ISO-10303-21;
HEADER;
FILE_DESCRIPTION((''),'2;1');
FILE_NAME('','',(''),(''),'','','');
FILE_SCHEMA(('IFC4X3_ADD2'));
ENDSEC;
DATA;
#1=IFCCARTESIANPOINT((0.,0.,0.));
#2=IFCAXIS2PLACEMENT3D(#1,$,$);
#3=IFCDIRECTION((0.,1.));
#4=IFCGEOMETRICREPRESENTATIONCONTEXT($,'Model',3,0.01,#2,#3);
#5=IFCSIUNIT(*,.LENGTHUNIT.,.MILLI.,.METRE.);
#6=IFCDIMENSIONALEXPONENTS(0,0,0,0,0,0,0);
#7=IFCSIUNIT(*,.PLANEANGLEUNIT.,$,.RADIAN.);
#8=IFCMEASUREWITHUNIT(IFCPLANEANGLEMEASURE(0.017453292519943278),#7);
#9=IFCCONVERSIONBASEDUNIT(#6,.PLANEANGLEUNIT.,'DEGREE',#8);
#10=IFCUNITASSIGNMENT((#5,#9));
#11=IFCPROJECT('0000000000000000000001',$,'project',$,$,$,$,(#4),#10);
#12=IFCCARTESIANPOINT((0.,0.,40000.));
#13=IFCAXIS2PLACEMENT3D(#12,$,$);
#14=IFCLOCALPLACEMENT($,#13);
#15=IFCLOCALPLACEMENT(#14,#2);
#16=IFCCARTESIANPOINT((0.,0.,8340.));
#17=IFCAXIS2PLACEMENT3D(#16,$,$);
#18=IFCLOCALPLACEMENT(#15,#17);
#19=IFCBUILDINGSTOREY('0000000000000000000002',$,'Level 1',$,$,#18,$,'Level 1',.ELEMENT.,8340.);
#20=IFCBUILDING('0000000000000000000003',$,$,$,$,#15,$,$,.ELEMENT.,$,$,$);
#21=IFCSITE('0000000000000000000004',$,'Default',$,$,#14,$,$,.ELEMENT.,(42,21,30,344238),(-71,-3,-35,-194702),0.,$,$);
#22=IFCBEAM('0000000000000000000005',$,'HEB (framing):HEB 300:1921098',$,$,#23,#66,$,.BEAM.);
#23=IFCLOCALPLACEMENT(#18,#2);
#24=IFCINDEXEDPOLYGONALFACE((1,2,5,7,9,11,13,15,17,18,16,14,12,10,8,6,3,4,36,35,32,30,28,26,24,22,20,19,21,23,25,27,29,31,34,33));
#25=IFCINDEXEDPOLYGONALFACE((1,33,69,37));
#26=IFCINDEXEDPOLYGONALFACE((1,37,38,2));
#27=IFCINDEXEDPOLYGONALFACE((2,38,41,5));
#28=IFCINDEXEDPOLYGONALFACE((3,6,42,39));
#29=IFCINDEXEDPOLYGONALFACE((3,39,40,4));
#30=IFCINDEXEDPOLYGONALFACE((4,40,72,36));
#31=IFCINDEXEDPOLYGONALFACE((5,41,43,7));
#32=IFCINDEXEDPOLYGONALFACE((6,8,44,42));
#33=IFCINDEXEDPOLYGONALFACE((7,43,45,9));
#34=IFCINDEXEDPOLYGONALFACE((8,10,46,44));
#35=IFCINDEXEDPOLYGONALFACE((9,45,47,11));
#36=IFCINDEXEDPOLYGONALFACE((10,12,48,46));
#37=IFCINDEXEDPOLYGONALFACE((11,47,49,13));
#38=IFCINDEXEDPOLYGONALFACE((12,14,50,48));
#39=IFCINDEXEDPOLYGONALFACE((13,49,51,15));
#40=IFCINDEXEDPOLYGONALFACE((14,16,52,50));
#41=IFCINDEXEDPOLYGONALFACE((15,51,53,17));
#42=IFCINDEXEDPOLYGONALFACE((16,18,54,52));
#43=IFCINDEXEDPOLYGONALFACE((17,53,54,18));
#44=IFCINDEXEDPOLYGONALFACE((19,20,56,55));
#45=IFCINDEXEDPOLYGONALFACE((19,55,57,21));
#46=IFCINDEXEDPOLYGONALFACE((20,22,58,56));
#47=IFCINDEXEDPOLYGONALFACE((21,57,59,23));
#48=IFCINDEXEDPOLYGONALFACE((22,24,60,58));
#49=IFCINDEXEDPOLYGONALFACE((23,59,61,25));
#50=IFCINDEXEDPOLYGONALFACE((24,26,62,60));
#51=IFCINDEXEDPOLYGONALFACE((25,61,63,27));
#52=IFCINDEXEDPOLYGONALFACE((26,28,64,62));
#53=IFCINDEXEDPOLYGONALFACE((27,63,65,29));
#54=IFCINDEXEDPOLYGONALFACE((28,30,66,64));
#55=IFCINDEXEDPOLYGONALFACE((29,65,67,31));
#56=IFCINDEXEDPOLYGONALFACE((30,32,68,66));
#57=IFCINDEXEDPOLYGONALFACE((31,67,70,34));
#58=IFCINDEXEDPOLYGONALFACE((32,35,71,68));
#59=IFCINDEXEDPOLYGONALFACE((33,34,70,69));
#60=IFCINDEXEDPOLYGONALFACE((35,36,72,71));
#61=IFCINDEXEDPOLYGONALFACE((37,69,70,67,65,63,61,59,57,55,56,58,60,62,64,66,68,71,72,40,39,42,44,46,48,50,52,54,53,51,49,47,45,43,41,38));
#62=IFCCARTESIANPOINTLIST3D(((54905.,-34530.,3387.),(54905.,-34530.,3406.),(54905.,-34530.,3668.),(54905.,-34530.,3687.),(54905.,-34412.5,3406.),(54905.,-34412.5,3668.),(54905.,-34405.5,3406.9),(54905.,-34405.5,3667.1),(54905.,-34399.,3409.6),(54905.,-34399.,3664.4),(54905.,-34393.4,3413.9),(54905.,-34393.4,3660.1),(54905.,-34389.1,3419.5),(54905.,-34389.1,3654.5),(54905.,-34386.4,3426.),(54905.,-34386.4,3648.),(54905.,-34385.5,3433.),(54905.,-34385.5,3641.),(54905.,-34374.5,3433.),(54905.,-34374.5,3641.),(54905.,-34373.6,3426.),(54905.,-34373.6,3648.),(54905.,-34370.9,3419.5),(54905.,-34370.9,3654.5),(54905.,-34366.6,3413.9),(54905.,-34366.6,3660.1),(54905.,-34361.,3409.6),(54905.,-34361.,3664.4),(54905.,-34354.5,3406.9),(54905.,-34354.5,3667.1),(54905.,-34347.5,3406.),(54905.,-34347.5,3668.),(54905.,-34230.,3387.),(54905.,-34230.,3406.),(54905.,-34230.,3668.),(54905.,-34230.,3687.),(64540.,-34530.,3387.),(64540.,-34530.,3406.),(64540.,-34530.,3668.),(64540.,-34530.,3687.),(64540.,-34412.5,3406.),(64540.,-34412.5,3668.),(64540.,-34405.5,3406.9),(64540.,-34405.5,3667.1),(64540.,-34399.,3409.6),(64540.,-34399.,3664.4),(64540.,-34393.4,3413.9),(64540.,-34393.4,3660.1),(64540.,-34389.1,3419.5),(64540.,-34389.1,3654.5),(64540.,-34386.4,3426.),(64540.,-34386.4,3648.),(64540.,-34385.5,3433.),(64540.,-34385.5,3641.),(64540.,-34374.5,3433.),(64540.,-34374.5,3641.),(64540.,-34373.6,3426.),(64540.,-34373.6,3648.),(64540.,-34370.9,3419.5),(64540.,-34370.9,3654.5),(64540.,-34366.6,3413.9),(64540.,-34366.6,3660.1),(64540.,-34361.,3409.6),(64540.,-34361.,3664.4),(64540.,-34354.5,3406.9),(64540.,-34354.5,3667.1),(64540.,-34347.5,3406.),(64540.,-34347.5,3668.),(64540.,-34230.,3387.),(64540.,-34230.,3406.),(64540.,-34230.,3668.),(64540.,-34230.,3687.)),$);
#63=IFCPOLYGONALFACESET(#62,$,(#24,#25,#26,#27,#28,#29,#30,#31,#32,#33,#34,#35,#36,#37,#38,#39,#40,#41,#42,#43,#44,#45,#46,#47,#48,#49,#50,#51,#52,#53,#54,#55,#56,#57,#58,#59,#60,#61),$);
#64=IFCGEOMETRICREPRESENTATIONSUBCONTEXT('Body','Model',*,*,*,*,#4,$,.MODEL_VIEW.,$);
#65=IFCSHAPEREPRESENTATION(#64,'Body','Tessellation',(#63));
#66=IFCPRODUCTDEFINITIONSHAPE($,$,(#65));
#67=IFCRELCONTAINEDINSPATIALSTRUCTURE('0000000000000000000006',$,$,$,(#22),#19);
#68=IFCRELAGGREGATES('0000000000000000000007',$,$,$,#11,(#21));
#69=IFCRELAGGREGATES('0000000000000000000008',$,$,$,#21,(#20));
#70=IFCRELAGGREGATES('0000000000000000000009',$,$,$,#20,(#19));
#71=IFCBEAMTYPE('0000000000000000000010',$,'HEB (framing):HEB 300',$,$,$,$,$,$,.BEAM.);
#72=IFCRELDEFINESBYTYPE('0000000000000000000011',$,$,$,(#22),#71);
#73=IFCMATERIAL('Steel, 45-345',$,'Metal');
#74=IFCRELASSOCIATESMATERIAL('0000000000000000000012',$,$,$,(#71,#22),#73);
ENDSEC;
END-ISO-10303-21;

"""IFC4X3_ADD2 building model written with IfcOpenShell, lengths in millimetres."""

from ifc_helpers import new_model, entity, si_unit, converted_unit, direction, frame, frame_2d, origin, place, context, subcontext, project, spatial, polyline, circle_curve, parameter, trimmed, segment, composite_curve, outline, extrude, source, transform, mapped, material, material_profile, profile_set, profile_usage, type_object, type_shapes, element, save


model = new_model("IFC4X3_ADD2")

# Units and contexts
model_context = context("Model", 3, precision=0.01, world=origin(), true_north=direction((0.0, 1.0)))
body_context = subcontext(model_context, "Body", "Model", "MODEL_VIEW")
ifc_project = project(units=[si_unit("LENGTHUNIT", "METRE", prefix="MILLI"), converted_unit("PLANEANGLEUNIT", "DEGREE", entity("IfcPlaneAngleMeasure", 0.017453292519943278), si_unit("PLANEANGLEUNIT", "RADIAN"), dimensions=[0, 0, 0, 0, 0, 0, 0])], contexts=[model_context])

# Site, building, storey
site_placement = place(None, frame((0.0, 0.0, 40000.0)))
site = spatial("IfcSite", under=ifc_project, at=site_placement, Name="Default", CompositionType="ELEMENT", RefLatitude=(42, 21, 30, 344238), RefLongitude=(-71, -3, -35, -194702), RefElevation=0.0)
building_placement = place(site_placement, origin())
building = spatial("IfcBuilding", under=site, at=building_placement, CompositionType="ELEMENT")
storey_placement = place(building_placement, frame((0.0, 0.0, 8340.0)))
storey = spatial("IfcBuildingStorey", under=building, at=storey_placement, Name="Level 1", LongName="Level 1", CompositionType="ELEMENT", Elevation=8340.0)

# Shared definitions
ifc_material_1 = material(Name="Steel, 45-345", Category="Metal")

# Beam
ifc_material_profile_1 = material_profile(ifc_material_1, outline(composite_curve([segment(polyline([(-150.0, -131.0), (-150.0, -150.0)]), True, "CONTINUOUS"), segment(polyline([(-150.0, -150.0), (150.0, -150.0)]), True, "CONTINUOUS"), segment(polyline([(150.0, -150.0), (150.0, -131.0)]), True, "CONTINUOUS"), segment(polyline([(150.0, -131.0), (32.5, -131.0)]), True, "CONTINUOUS"), segment(trimmed(circle_curve(frame_2d((32.5, -104.0), x_axis=(1.0, 0.0)), 27.0), [parameter(180.0)], [parameter(270.0)], True, "PARAMETER"), False, "CONTINUOUS"), segment(polyline([(5.5, -104.0), (5.5, 104.0)]), True, "CONTINUOUS"), segment(trimmed(circle_curve(frame_2d((32.5, 104.0), x_axis=(1.0, 0.0)), 27.0), [parameter(90.0)], [parameter(180.0)], True, "PARAMETER"), False, "CONTINUOUS"), segment(polyline([(32.5, 131.0), (150.0, 131.0)]), True, "CONTINUOUS"), segment(polyline([(150.0, 131.0), (150.0, 150.0)]), True, "CONTINUOUS"), segment(polyline([(150.0, 150.0), (-150.0, 150.0)]), True, "CONTINUOUS"), segment(polyline([(-150.0, 150.0), (-150.0, 131.0)]), True, "CONTINUOUS"), segment(polyline([(-150.0, 131.0), (-32.5, 131.0)]), True, "CONTINUOUS"), segment(trimmed(circle_curve(frame_2d((-32.5, 104.0), x_axis=(1.0, 0.0)), 27.0), [parameter(360.0)], [parameter(90.0)], True, "PARAMETER"), False, "CONTINUOUS"), segment(polyline([(-5.5, 104.0), (-5.5, -104.0)]), True, "CONTINUOUS"), segment(trimmed(circle_curve(frame_2d((-32.5, -104.0), x_axis=(1.0, 0.0)), 27.0), [parameter(270.0)], [parameter(0.0)], True, "PARAMETER"), False, "CONTINUOUS"), segment(polyline([(-32.5, -131.0), (-150.0, -131.0)]), True, "CONTINUOUS")], self_intersect=False)), Name="HEB 300")
ifc_profile_set_1 = profile_set([ifc_material_profile_1], Name="HEB 300")
ifc_profile_usage_1 = profile_usage(ifc_profile_set_1, cardinal=8)
beam_type_1 = type_object("IfcBeamType", Name="HEB (framing):HEB 300", PredefinedType="BEAM", material=ifc_profile_set_1)
shared_shape_1 = source(origin(), body_context, "Body", "SweptSolid", [
    extrude(outline(composite_curve([segment(polyline([(-150.0, -131.0), (-150.0, -150.0)]), True, "CONTINUOUS"), segment(polyline([(-150.0, -150.0), (150.0, -150.0)]), True, "CONTINUOUS"), segment(polyline([(150.0, -150.0), (150.0, -131.0)]), True, "CONTINUOUS"), segment(polyline([(150.0, -131.0), (32.5, -131.0)]), True, "CONTINUOUS"), segment(trimmed(circle_curve(frame_2d((32.5, -104.0), x_axis=(1.0, 0.0)), 27.0), [parameter(180.0)], [parameter(270.0)], True, "PARAMETER"), False, "CONTINUOUS"), segment(polyline([(5.5, -104.0), (5.5, 104.0)]), True, "CONTINUOUS"), segment(trimmed(circle_curve(frame_2d((32.5, 104.0), x_axis=(1.0, 0.0)), 27.0), [parameter(90.0)], [parameter(180.0)], True, "PARAMETER"), False, "CONTINUOUS"), segment(polyline([(32.5, 131.0), (150.0, 131.0)]), True, "CONTINUOUS"), segment(polyline([(150.0, 131.0), (150.0, 150.0)]), True, "CONTINUOUS"), segment(polyline([(150.0, 150.0), (-150.0, 150.0)]), True, "CONTINUOUS"), segment(polyline([(-150.0, 150.0), (-150.0, 131.0)]), True, "CONTINUOUS"), segment(polyline([(-150.0, 131.0), (-32.5, 131.0)]), True, "CONTINUOUS"), segment(trimmed(circle_curve(frame_2d((-32.5, 104.0), x_axis=(1.0, 0.0)), 27.0), [parameter(360.0)], [parameter(90.0)], True, "PARAMETER"), False, "CONTINUOUS"), segment(polyline([(-5.5, 104.0), (-5.5, -104.0)]), True, "CONTINUOUS"), segment(trimmed(circle_curve(frame_2d((-32.5, -104.0), x_axis=(1.0, 0.0)), 27.0), [parameter(270.0)], [parameter(0.0)], True, "PARAMETER"), False, "CONTINUOUS"), segment(polyline([(-32.5, -131.0), (-150.0, -131.0)]), True, "CONTINUOUS")], self_intersect=False)), frame((-4700.0, 0.0, 0.0), z_axis=(-1.0, 0.0, 0.0), x_axis=(0.0, -1.0, 0.0)), (0.0, 0.0, -1.0), 9635.0),
])
type_shapes(beam_type_1, [shared_shape_1])
beam_1_placement = place(storey_placement, frame((59605.0, -34380.0, 3537.0)))
element("IfcBeam", 1, at=beam_1_placement, inside=storey, type_object=beam_type_1, material=ifc_profile_usage_1, Name="HEB (framing):HEB 300:1921098", PredefinedType="BEAM", context=body_context, shape_type="MappedRepresentation", body=[
    mapped(shared_shape_1, transform((0.0, 0.0, 0.0), scale=1.0)),
])

save(model, "model.ifc")
